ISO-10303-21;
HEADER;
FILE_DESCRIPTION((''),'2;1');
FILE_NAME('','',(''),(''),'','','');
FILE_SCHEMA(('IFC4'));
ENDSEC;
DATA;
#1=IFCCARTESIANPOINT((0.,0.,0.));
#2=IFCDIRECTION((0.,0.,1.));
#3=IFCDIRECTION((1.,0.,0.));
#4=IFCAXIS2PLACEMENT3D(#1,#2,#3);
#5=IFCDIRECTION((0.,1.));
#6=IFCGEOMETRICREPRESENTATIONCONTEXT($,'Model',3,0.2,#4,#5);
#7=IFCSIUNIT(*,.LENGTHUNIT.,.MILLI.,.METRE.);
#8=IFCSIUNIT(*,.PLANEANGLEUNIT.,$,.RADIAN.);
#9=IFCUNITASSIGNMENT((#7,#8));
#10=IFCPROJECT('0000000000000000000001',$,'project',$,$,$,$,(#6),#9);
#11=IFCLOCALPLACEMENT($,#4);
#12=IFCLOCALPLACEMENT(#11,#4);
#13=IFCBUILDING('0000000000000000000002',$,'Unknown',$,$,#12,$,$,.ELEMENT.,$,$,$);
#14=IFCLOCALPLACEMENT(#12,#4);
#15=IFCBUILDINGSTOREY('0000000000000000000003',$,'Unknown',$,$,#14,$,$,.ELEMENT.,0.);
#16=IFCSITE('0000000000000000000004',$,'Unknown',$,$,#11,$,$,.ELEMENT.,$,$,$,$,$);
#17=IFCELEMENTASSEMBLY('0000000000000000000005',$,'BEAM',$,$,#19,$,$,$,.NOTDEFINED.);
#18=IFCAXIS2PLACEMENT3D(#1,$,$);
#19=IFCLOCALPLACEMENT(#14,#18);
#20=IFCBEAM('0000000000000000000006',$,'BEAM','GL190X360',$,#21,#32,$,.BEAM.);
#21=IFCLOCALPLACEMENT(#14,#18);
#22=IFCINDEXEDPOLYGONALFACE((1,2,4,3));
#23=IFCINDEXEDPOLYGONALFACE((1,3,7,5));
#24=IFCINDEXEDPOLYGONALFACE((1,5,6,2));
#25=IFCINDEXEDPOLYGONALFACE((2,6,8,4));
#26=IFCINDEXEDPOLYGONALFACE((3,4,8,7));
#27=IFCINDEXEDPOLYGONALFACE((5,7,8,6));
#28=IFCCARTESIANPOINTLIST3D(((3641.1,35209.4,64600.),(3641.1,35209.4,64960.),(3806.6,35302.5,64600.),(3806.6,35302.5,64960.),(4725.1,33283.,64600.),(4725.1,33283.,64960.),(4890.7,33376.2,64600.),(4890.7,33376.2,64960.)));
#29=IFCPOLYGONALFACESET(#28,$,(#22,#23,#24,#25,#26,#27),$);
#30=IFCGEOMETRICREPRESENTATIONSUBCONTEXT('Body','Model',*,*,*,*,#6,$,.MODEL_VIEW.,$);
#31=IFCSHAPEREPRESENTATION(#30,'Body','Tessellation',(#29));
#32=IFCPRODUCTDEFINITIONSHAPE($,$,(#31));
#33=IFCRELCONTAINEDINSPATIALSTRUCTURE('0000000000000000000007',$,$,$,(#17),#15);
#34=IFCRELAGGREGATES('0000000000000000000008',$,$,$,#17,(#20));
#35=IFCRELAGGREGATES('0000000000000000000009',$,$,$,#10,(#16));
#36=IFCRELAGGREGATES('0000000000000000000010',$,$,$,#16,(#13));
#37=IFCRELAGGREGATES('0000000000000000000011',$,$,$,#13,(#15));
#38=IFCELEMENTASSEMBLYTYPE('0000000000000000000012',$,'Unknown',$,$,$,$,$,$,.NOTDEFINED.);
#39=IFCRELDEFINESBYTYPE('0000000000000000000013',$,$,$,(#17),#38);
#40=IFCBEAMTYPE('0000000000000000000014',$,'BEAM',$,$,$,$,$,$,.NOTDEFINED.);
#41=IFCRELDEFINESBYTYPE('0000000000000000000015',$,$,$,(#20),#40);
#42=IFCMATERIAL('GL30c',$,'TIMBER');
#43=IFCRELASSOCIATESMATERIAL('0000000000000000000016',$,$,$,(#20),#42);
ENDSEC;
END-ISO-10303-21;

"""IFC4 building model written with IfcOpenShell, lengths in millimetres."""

from ifc_helpers import new_model, si_unit, direction, frame, origin_with_axes, place, context, subcontext, project, spatial, polyline, outline, extrude, material, material_profile, profile_set, profile_usage, type_object, element, aggregate, save


model = new_model("IFC4")

# Units and contexts
model_context = context("Model", 3, precision=0.2, world=origin_with_axes(), true_north=direction((0.0, 1.0)))
body_context = subcontext(model_context, "Body", "Model", "MODEL_VIEW")
ifc_project = project(units=[si_unit("LENGTHUNIT", "METRE", prefix="MILLI"), si_unit("PLANEANGLEUNIT", "RADIAN")], contexts=[model_context])

# Site, building, storey
site_placement = place(None, origin_with_axes())
site = spatial("IfcSite", under=ifc_project, at=site_placement, Name="Unknown", CompositionType="ELEMENT")
building_placement = place(site_placement, origin_with_axes())
building = spatial("IfcBuilding", under=site, at=building_placement, Name="Unknown", CompositionType="ELEMENT")
storey_placement = place(building_placement, origin_with_axes())
storey = spatial("IfcBuildingStorey", under=building, at=storey_placement, Name="Unknown", CompositionType="ELEMENT", Elevation=0.0)

# Shared definitions
element_assembly_type = type_object("IfcElementAssemblyType", Name="Unknown", PredefinedType="NOTDEFINED")
ifc_material_1 = material(Name="GL30c", Category="TIMBER")

# Element assembly, beam
ifc_material_profile_1 = material_profile(ifc_material_1, outline(polyline([(-95.0, 180.0), (-95.0, -180.0), (95.0, -180.0), (95.0, 180.0), (-95.0, 180.0)])), Name="GL190X360")
ifc_profile_set_1 = profile_set([ifc_material_profile_1])
ifc_profile_usage_1 = profile_usage(ifc_profile_set_1, cardinal=8)
beam_type_1 = type_object("IfcBeamType", Name="BEAM")
assembly_1_placement = place(storey_placement, frame((3723.9, 35256.0, 64780.0), z_axis=(-0.871487, -0.490418, 0.0), x_axis=(0.490421, -0.871485, 0.0)))
assembly_1 = element("IfcElementAssembly", 1, at=assembly_1_placement, inside=storey, type_object=element_assembly_type, Name="BEAM", PredefinedType="NOTDEFINED")
beam_1_placement = place(assembly_1_placement, origin_with_axes())
beam_1 = element("IfcBeam", 2, at=beam_1_placement, type_object=beam_type_1, material=ifc_profile_usage_1, Name="BEAM", Description="GL190X360", PredefinedType="BEAM", context=body_context, shape_type="SolidModel", body=[
    extrude(outline(polyline([(-95.0, 180.0), (-95.0, -180.0), (95.0, -180.0), (95.0, 180.0), (-95.0, 180.0)])), frame((0.0, 0.0, 0.0), z_axis=(-1.0, 0.0, 0.0), x_axis=(0.0, 0.0, 1.0)), (0.0, 0.0, -1.0), 2210.4),
])
aggregate(assembly_1, [beam_1])

save(model, "model.ifc")
